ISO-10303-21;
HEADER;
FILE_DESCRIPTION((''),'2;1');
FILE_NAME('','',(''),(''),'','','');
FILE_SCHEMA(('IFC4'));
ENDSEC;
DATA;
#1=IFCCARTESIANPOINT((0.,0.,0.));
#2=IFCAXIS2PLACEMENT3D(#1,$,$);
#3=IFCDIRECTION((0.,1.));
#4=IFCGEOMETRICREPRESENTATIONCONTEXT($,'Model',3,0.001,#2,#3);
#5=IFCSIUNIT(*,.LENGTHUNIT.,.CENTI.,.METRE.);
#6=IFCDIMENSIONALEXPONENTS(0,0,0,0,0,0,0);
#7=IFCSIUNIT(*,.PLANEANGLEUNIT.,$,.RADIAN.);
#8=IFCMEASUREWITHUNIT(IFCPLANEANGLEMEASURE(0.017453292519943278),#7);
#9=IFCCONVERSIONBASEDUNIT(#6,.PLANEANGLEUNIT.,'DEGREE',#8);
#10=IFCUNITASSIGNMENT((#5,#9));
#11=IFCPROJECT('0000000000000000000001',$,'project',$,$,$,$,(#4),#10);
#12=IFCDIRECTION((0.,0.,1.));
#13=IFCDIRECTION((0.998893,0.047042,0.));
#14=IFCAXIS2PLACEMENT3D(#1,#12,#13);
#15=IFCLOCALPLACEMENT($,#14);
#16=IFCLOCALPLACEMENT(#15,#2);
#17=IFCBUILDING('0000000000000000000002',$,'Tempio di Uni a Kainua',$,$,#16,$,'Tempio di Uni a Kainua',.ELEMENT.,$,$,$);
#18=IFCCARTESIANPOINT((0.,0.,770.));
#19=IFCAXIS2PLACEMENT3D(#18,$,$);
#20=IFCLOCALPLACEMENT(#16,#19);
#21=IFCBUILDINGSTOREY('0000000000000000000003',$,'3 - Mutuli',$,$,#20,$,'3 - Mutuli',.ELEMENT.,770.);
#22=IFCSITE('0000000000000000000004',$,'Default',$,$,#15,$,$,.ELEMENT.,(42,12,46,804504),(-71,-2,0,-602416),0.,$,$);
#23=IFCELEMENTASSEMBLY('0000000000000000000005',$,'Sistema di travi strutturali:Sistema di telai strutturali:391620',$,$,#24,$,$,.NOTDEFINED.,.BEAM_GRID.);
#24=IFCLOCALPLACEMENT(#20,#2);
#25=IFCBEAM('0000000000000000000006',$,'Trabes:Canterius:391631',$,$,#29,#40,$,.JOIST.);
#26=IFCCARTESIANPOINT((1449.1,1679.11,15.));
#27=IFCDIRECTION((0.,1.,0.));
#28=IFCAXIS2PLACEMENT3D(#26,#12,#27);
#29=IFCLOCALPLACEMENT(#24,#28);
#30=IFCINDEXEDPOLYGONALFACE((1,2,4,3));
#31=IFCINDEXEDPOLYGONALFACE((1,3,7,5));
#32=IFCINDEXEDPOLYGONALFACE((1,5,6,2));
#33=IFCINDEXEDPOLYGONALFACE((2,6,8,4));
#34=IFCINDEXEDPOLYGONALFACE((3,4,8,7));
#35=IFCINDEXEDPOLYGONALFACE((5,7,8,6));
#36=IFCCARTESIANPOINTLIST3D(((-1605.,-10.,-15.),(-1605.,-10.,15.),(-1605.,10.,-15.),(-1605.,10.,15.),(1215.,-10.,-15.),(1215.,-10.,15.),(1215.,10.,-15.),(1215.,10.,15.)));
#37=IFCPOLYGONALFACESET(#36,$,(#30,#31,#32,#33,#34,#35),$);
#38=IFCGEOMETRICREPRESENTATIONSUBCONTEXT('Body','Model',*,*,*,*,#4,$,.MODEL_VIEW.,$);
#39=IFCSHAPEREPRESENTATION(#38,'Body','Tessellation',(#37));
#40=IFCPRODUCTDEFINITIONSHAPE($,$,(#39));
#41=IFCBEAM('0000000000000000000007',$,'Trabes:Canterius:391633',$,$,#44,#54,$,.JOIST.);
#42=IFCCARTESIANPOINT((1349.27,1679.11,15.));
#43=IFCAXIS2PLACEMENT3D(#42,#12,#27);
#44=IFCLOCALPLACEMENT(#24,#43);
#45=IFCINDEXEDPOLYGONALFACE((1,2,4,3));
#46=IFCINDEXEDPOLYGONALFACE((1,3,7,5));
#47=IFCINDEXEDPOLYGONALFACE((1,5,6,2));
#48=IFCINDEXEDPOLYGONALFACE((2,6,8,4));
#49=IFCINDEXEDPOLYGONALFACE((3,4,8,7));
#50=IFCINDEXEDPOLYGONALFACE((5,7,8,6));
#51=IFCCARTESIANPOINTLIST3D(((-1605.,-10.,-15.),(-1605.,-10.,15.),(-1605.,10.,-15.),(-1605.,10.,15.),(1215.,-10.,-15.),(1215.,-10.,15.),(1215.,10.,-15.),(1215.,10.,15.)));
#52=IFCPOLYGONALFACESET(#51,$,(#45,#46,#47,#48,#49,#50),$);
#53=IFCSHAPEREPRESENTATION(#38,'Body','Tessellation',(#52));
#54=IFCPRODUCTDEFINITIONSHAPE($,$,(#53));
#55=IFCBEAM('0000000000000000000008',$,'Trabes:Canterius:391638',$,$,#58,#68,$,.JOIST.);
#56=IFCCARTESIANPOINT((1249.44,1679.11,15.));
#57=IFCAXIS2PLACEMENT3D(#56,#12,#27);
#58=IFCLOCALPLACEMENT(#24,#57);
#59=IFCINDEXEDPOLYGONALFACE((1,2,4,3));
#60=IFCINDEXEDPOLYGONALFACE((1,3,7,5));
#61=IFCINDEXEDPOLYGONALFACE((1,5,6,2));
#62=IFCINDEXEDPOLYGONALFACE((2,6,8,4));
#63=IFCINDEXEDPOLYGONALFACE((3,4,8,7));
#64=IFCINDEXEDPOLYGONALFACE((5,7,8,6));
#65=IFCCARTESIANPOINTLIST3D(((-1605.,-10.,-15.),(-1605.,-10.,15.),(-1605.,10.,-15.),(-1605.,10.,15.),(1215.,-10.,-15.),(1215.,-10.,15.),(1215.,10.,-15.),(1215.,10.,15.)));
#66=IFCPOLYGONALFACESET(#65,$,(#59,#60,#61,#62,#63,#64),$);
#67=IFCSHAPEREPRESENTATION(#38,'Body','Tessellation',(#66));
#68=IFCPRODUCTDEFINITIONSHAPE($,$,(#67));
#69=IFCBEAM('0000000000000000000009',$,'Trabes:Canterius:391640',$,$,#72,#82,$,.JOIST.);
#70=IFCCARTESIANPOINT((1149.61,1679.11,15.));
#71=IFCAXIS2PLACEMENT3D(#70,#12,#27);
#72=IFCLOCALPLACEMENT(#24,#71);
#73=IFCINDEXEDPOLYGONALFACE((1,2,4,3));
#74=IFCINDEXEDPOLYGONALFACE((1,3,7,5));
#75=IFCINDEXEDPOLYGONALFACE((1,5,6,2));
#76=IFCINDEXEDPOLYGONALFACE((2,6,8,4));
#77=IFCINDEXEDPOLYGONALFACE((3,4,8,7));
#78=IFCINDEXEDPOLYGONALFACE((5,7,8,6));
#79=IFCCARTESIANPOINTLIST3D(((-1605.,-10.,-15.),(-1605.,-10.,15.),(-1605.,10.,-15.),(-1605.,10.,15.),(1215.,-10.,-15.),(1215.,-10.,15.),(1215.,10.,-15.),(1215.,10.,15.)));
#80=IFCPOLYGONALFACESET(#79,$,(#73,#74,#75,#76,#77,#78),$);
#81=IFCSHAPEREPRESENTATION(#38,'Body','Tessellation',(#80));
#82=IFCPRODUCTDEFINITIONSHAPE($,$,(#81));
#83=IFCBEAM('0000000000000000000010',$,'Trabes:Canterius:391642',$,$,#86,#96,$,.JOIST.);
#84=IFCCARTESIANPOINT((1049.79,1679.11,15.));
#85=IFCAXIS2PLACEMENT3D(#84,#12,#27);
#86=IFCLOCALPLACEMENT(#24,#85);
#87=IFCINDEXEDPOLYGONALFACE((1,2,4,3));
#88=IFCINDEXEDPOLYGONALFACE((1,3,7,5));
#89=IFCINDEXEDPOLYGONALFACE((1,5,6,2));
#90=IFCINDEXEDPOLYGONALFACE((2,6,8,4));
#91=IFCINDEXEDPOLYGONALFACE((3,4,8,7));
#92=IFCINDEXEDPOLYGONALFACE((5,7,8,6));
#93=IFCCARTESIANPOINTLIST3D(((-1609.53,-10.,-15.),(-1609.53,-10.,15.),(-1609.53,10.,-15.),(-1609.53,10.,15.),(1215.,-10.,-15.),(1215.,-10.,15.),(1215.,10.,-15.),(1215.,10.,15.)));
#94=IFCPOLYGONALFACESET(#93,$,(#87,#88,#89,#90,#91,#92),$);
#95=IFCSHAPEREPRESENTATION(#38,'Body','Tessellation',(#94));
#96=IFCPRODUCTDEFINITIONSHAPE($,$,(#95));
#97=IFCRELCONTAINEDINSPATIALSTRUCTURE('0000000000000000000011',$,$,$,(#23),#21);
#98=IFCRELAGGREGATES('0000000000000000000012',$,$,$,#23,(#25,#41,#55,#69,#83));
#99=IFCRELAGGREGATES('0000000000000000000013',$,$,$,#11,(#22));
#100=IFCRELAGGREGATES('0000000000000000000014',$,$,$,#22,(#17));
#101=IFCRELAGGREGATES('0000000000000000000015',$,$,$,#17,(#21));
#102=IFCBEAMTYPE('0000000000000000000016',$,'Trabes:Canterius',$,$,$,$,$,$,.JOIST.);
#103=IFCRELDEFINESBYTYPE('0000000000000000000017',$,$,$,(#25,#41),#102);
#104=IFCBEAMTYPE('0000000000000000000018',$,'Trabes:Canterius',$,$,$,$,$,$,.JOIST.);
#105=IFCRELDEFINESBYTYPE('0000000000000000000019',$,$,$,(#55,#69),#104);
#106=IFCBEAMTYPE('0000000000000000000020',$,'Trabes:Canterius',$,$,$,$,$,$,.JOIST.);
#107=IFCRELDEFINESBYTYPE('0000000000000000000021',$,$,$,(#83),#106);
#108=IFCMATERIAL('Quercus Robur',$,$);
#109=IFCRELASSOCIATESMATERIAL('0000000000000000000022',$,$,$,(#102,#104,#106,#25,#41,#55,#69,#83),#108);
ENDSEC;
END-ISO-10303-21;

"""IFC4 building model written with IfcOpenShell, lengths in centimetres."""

from ifc_helpers import new_model, entity, si_unit, converted_unit, direction, frame, origin, origin_2d_with_axis, place, context, subcontext, project, spatial, rectangle, extrude, source, transform, mapped, material, material_profile, profile_set, profile_usage, type_object, type_shapes, element, aggregate, save


model = new_model("IFC4")

# Units and contexts
model_context = context("Model", 3, precision=0.001, world=origin(), true_north=direction((0.0, 1.0)))
body_context = subcontext(model_context, "Body", "Model", "MODEL_VIEW")
ifc_project = project(units=[si_unit("LENGTHUNIT", "METRE", prefix="CENTI"), converted_unit("PLANEANGLEUNIT", "DEGREE", entity("IfcPlaneAngleMeasure", 0.017453292519943278), si_unit("PLANEANGLEUNIT", "RADIAN"), dimensions=[0, 0, 0, 0, 0, 0, 0])], contexts=[model_context])

# Site, building, storey
site_placement = place(None, frame((0.0, 0.0, 0.0), z_axis=(0.0, 0.0, 1.0), x_axis=(0.998893, 0.047042, 0.0)))
site = spatial("IfcSite", under=ifc_project, at=site_placement, Name="Default", CompositionType="ELEMENT", RefLatitude=(42, 12, 46, 804504), RefLongitude=(-71, -2, 0, -602416), RefElevation=0.0)
building_placement = place(site_placement, origin())
building = spatial("IfcBuilding", under=site, at=building_placement, Name="Tempio di Uni a Kainua", LongName="Tempio di Uni a Kainua", CompositionType="ELEMENT")
storey_placement = place(building_placement, frame((0.0, 0.0, 770.0)))
storey = spatial("IfcBuildingStorey", under=building, at=storey_placement, Name="3 - Mutuli", LongName="3 - Mutuli", CompositionType="ELEMENT", Elevation=770.0)

# Shared definitions
ifc_material = material(Name="Quercus Robur")

# Shared definitions
ifc_material_profile_1 = material_profile(ifc_material, rectangle(XDim=2590.0, YDim=20.0, at=origin_2d_with_axis()), Name="Canterius")
ifc_profile_set_1 = profile_set([ifc_material_profile_1], Name="Canterius")
ifc_profile_usage_1 = profile_usage(ifc_profile_set_1, cardinal=3)

# Element assembly, beams
assembly_1_placement = place(storey_placement, origin())
assembly_1 = element("IfcElementAssembly", 1, at=assembly_1_placement, inside=storey, Name="Sistema di travi strutturali:Sistema di telai strutturali:391620", AssemblyPlace="NOTDEFINED", PredefinedType="BEAM_GRID")
beam_type_1 = type_object("IfcBeamType", Name="Trabes:Canterius", PredefinedType="JOIST", material=ifc_profile_set_1)
shared_shape_1 = source(origin(), body_context, "Body", "SweptSolid", [
    extrude(rectangle(XDim=2820.0, YDim=20.0, at=origin_2d_with_axis()), frame((-195.0, 0.0, -15.0)), (0.0, 0.0, 1.0), 30.0),
])
type_shapes(beam_type_1, [shared_shape_1])
beam_1_placement = place(assembly_1_placement, frame((1449.1, 1679.11, 15.0), z_axis=(0.0, 0.0, 1.0), x_axis=(0.0, 1.0, 0.0)))
beam_1 = element("IfcBeam", 2, at=beam_1_placement, type_object=beam_type_1, material=ifc_profile_usage_1, Name="Trabes:Canterius:391631", PredefinedType="JOIST", context=body_context, shape_type="MappedRepresentation", body=[
    mapped(shared_shape_1, transform((0.0, 0.0, 0.0), scale=1.0)),
])
beam_2_placement = place(assembly_1_placement, frame((1349.27, 1679.11, 15.0), z_axis=(0.0, 0.0, 1.0), x_axis=(0.0, 1.0, 0.0)))
beam_2 = element("IfcBeam", 3, at=beam_2_placement, type_object=beam_type_1, material=ifc_profile_usage_1, Name="Trabes:Canterius:391633", PredefinedType="JOIST", context=body_context, shape_type="MappedRepresentation", body=[
    mapped(shared_shape_1, transform((0.0, 0.0, 0.0), scale=1.0)),
])
beam_type_2 = type_object("IfcBeamType", Name="Trabes:Canterius", PredefinedType="JOIST", material=ifc_profile_set_1)
shared_shape_2 = source(origin(), body_context, "Body", "SweptSolid", [
    extrude(rectangle(XDim=2820.0, YDim=20.0, at=origin_2d_with_axis()), frame((-195.0, 0.0, -15.0)), (0.0, 0.0, 1.0), 30.0),
])
type_shapes(beam_type_2, [shared_shape_2])
beam_3_placement = place(assembly_1_placement, frame((1249.44, 1679.11, 15.0), z_axis=(0.0, 0.0, 1.0), x_axis=(0.0, 1.0, 0.0)))
beam_3 = element("IfcBeam", 4, at=beam_3_placement, type_object=beam_type_2, material=ifc_profile_usage_1, Name="Trabes:Canterius:391638", PredefinedType="JOIST", context=body_context, shape_type="MappedRepresentation", body=[
    mapped(shared_shape_2, transform((0.0, 0.0, 0.0), scale=1.0)),
])
beam_4_placement = place(assembly_1_placement, frame((1149.61, 1679.11, 15.0), z_axis=(0.0, 0.0, 1.0), x_axis=(0.0, 1.0, 0.0)))
beam_4 = element("IfcBeam", 5, at=beam_4_placement, type_object=beam_type_2, material=ifc_profile_usage_1, Name="Trabes:Canterius:391640", PredefinedType="JOIST", context=body_context, shape_type="MappedRepresentation", body=[
    mapped(shared_shape_2, transform((0.0, 0.0, 0.0), scale=1.0)),
])
beam_type_3 = type_object("IfcBeamType", Name="Trabes:Canterius", PredefinedType="JOIST", material=ifc_profile_set_1)
shared_shape_3 = source(origin(), body_context, "Body", "SweptSolid", [
    extrude(rectangle(XDim=2824.53, YDim=20.0, at=origin_2d_with_axis()), frame((-197.27, 0.0, -15.0)), (0.0, 0.0, 1.0), 30.0),
])
type_shapes(beam_type_3, [shared_shape_3])
beam_5_placement = place(assembly_1_placement, frame((1049.79, 1679.11, 15.0), z_axis=(0.0, 0.0, 1.0), x_axis=(0.0, 1.0, 0.0)))
beam_5 = element("IfcBeam", 6, at=beam_5_placement, type_object=beam_type_3, material=ifc_profile_usage_1, Name="Trabes:Canterius:391642", PredefinedType="JOIST", context=body_context, shape_type="MappedRepresentation", body=[
    mapped(shared_shape_3, transform((0.0, 0.0, 0.0), scale=1.0)),
])
aggregate(assembly_1, [beam_1, beam_2, beam_3, beam_4, beam_5])

save(model, "model.ifc")
